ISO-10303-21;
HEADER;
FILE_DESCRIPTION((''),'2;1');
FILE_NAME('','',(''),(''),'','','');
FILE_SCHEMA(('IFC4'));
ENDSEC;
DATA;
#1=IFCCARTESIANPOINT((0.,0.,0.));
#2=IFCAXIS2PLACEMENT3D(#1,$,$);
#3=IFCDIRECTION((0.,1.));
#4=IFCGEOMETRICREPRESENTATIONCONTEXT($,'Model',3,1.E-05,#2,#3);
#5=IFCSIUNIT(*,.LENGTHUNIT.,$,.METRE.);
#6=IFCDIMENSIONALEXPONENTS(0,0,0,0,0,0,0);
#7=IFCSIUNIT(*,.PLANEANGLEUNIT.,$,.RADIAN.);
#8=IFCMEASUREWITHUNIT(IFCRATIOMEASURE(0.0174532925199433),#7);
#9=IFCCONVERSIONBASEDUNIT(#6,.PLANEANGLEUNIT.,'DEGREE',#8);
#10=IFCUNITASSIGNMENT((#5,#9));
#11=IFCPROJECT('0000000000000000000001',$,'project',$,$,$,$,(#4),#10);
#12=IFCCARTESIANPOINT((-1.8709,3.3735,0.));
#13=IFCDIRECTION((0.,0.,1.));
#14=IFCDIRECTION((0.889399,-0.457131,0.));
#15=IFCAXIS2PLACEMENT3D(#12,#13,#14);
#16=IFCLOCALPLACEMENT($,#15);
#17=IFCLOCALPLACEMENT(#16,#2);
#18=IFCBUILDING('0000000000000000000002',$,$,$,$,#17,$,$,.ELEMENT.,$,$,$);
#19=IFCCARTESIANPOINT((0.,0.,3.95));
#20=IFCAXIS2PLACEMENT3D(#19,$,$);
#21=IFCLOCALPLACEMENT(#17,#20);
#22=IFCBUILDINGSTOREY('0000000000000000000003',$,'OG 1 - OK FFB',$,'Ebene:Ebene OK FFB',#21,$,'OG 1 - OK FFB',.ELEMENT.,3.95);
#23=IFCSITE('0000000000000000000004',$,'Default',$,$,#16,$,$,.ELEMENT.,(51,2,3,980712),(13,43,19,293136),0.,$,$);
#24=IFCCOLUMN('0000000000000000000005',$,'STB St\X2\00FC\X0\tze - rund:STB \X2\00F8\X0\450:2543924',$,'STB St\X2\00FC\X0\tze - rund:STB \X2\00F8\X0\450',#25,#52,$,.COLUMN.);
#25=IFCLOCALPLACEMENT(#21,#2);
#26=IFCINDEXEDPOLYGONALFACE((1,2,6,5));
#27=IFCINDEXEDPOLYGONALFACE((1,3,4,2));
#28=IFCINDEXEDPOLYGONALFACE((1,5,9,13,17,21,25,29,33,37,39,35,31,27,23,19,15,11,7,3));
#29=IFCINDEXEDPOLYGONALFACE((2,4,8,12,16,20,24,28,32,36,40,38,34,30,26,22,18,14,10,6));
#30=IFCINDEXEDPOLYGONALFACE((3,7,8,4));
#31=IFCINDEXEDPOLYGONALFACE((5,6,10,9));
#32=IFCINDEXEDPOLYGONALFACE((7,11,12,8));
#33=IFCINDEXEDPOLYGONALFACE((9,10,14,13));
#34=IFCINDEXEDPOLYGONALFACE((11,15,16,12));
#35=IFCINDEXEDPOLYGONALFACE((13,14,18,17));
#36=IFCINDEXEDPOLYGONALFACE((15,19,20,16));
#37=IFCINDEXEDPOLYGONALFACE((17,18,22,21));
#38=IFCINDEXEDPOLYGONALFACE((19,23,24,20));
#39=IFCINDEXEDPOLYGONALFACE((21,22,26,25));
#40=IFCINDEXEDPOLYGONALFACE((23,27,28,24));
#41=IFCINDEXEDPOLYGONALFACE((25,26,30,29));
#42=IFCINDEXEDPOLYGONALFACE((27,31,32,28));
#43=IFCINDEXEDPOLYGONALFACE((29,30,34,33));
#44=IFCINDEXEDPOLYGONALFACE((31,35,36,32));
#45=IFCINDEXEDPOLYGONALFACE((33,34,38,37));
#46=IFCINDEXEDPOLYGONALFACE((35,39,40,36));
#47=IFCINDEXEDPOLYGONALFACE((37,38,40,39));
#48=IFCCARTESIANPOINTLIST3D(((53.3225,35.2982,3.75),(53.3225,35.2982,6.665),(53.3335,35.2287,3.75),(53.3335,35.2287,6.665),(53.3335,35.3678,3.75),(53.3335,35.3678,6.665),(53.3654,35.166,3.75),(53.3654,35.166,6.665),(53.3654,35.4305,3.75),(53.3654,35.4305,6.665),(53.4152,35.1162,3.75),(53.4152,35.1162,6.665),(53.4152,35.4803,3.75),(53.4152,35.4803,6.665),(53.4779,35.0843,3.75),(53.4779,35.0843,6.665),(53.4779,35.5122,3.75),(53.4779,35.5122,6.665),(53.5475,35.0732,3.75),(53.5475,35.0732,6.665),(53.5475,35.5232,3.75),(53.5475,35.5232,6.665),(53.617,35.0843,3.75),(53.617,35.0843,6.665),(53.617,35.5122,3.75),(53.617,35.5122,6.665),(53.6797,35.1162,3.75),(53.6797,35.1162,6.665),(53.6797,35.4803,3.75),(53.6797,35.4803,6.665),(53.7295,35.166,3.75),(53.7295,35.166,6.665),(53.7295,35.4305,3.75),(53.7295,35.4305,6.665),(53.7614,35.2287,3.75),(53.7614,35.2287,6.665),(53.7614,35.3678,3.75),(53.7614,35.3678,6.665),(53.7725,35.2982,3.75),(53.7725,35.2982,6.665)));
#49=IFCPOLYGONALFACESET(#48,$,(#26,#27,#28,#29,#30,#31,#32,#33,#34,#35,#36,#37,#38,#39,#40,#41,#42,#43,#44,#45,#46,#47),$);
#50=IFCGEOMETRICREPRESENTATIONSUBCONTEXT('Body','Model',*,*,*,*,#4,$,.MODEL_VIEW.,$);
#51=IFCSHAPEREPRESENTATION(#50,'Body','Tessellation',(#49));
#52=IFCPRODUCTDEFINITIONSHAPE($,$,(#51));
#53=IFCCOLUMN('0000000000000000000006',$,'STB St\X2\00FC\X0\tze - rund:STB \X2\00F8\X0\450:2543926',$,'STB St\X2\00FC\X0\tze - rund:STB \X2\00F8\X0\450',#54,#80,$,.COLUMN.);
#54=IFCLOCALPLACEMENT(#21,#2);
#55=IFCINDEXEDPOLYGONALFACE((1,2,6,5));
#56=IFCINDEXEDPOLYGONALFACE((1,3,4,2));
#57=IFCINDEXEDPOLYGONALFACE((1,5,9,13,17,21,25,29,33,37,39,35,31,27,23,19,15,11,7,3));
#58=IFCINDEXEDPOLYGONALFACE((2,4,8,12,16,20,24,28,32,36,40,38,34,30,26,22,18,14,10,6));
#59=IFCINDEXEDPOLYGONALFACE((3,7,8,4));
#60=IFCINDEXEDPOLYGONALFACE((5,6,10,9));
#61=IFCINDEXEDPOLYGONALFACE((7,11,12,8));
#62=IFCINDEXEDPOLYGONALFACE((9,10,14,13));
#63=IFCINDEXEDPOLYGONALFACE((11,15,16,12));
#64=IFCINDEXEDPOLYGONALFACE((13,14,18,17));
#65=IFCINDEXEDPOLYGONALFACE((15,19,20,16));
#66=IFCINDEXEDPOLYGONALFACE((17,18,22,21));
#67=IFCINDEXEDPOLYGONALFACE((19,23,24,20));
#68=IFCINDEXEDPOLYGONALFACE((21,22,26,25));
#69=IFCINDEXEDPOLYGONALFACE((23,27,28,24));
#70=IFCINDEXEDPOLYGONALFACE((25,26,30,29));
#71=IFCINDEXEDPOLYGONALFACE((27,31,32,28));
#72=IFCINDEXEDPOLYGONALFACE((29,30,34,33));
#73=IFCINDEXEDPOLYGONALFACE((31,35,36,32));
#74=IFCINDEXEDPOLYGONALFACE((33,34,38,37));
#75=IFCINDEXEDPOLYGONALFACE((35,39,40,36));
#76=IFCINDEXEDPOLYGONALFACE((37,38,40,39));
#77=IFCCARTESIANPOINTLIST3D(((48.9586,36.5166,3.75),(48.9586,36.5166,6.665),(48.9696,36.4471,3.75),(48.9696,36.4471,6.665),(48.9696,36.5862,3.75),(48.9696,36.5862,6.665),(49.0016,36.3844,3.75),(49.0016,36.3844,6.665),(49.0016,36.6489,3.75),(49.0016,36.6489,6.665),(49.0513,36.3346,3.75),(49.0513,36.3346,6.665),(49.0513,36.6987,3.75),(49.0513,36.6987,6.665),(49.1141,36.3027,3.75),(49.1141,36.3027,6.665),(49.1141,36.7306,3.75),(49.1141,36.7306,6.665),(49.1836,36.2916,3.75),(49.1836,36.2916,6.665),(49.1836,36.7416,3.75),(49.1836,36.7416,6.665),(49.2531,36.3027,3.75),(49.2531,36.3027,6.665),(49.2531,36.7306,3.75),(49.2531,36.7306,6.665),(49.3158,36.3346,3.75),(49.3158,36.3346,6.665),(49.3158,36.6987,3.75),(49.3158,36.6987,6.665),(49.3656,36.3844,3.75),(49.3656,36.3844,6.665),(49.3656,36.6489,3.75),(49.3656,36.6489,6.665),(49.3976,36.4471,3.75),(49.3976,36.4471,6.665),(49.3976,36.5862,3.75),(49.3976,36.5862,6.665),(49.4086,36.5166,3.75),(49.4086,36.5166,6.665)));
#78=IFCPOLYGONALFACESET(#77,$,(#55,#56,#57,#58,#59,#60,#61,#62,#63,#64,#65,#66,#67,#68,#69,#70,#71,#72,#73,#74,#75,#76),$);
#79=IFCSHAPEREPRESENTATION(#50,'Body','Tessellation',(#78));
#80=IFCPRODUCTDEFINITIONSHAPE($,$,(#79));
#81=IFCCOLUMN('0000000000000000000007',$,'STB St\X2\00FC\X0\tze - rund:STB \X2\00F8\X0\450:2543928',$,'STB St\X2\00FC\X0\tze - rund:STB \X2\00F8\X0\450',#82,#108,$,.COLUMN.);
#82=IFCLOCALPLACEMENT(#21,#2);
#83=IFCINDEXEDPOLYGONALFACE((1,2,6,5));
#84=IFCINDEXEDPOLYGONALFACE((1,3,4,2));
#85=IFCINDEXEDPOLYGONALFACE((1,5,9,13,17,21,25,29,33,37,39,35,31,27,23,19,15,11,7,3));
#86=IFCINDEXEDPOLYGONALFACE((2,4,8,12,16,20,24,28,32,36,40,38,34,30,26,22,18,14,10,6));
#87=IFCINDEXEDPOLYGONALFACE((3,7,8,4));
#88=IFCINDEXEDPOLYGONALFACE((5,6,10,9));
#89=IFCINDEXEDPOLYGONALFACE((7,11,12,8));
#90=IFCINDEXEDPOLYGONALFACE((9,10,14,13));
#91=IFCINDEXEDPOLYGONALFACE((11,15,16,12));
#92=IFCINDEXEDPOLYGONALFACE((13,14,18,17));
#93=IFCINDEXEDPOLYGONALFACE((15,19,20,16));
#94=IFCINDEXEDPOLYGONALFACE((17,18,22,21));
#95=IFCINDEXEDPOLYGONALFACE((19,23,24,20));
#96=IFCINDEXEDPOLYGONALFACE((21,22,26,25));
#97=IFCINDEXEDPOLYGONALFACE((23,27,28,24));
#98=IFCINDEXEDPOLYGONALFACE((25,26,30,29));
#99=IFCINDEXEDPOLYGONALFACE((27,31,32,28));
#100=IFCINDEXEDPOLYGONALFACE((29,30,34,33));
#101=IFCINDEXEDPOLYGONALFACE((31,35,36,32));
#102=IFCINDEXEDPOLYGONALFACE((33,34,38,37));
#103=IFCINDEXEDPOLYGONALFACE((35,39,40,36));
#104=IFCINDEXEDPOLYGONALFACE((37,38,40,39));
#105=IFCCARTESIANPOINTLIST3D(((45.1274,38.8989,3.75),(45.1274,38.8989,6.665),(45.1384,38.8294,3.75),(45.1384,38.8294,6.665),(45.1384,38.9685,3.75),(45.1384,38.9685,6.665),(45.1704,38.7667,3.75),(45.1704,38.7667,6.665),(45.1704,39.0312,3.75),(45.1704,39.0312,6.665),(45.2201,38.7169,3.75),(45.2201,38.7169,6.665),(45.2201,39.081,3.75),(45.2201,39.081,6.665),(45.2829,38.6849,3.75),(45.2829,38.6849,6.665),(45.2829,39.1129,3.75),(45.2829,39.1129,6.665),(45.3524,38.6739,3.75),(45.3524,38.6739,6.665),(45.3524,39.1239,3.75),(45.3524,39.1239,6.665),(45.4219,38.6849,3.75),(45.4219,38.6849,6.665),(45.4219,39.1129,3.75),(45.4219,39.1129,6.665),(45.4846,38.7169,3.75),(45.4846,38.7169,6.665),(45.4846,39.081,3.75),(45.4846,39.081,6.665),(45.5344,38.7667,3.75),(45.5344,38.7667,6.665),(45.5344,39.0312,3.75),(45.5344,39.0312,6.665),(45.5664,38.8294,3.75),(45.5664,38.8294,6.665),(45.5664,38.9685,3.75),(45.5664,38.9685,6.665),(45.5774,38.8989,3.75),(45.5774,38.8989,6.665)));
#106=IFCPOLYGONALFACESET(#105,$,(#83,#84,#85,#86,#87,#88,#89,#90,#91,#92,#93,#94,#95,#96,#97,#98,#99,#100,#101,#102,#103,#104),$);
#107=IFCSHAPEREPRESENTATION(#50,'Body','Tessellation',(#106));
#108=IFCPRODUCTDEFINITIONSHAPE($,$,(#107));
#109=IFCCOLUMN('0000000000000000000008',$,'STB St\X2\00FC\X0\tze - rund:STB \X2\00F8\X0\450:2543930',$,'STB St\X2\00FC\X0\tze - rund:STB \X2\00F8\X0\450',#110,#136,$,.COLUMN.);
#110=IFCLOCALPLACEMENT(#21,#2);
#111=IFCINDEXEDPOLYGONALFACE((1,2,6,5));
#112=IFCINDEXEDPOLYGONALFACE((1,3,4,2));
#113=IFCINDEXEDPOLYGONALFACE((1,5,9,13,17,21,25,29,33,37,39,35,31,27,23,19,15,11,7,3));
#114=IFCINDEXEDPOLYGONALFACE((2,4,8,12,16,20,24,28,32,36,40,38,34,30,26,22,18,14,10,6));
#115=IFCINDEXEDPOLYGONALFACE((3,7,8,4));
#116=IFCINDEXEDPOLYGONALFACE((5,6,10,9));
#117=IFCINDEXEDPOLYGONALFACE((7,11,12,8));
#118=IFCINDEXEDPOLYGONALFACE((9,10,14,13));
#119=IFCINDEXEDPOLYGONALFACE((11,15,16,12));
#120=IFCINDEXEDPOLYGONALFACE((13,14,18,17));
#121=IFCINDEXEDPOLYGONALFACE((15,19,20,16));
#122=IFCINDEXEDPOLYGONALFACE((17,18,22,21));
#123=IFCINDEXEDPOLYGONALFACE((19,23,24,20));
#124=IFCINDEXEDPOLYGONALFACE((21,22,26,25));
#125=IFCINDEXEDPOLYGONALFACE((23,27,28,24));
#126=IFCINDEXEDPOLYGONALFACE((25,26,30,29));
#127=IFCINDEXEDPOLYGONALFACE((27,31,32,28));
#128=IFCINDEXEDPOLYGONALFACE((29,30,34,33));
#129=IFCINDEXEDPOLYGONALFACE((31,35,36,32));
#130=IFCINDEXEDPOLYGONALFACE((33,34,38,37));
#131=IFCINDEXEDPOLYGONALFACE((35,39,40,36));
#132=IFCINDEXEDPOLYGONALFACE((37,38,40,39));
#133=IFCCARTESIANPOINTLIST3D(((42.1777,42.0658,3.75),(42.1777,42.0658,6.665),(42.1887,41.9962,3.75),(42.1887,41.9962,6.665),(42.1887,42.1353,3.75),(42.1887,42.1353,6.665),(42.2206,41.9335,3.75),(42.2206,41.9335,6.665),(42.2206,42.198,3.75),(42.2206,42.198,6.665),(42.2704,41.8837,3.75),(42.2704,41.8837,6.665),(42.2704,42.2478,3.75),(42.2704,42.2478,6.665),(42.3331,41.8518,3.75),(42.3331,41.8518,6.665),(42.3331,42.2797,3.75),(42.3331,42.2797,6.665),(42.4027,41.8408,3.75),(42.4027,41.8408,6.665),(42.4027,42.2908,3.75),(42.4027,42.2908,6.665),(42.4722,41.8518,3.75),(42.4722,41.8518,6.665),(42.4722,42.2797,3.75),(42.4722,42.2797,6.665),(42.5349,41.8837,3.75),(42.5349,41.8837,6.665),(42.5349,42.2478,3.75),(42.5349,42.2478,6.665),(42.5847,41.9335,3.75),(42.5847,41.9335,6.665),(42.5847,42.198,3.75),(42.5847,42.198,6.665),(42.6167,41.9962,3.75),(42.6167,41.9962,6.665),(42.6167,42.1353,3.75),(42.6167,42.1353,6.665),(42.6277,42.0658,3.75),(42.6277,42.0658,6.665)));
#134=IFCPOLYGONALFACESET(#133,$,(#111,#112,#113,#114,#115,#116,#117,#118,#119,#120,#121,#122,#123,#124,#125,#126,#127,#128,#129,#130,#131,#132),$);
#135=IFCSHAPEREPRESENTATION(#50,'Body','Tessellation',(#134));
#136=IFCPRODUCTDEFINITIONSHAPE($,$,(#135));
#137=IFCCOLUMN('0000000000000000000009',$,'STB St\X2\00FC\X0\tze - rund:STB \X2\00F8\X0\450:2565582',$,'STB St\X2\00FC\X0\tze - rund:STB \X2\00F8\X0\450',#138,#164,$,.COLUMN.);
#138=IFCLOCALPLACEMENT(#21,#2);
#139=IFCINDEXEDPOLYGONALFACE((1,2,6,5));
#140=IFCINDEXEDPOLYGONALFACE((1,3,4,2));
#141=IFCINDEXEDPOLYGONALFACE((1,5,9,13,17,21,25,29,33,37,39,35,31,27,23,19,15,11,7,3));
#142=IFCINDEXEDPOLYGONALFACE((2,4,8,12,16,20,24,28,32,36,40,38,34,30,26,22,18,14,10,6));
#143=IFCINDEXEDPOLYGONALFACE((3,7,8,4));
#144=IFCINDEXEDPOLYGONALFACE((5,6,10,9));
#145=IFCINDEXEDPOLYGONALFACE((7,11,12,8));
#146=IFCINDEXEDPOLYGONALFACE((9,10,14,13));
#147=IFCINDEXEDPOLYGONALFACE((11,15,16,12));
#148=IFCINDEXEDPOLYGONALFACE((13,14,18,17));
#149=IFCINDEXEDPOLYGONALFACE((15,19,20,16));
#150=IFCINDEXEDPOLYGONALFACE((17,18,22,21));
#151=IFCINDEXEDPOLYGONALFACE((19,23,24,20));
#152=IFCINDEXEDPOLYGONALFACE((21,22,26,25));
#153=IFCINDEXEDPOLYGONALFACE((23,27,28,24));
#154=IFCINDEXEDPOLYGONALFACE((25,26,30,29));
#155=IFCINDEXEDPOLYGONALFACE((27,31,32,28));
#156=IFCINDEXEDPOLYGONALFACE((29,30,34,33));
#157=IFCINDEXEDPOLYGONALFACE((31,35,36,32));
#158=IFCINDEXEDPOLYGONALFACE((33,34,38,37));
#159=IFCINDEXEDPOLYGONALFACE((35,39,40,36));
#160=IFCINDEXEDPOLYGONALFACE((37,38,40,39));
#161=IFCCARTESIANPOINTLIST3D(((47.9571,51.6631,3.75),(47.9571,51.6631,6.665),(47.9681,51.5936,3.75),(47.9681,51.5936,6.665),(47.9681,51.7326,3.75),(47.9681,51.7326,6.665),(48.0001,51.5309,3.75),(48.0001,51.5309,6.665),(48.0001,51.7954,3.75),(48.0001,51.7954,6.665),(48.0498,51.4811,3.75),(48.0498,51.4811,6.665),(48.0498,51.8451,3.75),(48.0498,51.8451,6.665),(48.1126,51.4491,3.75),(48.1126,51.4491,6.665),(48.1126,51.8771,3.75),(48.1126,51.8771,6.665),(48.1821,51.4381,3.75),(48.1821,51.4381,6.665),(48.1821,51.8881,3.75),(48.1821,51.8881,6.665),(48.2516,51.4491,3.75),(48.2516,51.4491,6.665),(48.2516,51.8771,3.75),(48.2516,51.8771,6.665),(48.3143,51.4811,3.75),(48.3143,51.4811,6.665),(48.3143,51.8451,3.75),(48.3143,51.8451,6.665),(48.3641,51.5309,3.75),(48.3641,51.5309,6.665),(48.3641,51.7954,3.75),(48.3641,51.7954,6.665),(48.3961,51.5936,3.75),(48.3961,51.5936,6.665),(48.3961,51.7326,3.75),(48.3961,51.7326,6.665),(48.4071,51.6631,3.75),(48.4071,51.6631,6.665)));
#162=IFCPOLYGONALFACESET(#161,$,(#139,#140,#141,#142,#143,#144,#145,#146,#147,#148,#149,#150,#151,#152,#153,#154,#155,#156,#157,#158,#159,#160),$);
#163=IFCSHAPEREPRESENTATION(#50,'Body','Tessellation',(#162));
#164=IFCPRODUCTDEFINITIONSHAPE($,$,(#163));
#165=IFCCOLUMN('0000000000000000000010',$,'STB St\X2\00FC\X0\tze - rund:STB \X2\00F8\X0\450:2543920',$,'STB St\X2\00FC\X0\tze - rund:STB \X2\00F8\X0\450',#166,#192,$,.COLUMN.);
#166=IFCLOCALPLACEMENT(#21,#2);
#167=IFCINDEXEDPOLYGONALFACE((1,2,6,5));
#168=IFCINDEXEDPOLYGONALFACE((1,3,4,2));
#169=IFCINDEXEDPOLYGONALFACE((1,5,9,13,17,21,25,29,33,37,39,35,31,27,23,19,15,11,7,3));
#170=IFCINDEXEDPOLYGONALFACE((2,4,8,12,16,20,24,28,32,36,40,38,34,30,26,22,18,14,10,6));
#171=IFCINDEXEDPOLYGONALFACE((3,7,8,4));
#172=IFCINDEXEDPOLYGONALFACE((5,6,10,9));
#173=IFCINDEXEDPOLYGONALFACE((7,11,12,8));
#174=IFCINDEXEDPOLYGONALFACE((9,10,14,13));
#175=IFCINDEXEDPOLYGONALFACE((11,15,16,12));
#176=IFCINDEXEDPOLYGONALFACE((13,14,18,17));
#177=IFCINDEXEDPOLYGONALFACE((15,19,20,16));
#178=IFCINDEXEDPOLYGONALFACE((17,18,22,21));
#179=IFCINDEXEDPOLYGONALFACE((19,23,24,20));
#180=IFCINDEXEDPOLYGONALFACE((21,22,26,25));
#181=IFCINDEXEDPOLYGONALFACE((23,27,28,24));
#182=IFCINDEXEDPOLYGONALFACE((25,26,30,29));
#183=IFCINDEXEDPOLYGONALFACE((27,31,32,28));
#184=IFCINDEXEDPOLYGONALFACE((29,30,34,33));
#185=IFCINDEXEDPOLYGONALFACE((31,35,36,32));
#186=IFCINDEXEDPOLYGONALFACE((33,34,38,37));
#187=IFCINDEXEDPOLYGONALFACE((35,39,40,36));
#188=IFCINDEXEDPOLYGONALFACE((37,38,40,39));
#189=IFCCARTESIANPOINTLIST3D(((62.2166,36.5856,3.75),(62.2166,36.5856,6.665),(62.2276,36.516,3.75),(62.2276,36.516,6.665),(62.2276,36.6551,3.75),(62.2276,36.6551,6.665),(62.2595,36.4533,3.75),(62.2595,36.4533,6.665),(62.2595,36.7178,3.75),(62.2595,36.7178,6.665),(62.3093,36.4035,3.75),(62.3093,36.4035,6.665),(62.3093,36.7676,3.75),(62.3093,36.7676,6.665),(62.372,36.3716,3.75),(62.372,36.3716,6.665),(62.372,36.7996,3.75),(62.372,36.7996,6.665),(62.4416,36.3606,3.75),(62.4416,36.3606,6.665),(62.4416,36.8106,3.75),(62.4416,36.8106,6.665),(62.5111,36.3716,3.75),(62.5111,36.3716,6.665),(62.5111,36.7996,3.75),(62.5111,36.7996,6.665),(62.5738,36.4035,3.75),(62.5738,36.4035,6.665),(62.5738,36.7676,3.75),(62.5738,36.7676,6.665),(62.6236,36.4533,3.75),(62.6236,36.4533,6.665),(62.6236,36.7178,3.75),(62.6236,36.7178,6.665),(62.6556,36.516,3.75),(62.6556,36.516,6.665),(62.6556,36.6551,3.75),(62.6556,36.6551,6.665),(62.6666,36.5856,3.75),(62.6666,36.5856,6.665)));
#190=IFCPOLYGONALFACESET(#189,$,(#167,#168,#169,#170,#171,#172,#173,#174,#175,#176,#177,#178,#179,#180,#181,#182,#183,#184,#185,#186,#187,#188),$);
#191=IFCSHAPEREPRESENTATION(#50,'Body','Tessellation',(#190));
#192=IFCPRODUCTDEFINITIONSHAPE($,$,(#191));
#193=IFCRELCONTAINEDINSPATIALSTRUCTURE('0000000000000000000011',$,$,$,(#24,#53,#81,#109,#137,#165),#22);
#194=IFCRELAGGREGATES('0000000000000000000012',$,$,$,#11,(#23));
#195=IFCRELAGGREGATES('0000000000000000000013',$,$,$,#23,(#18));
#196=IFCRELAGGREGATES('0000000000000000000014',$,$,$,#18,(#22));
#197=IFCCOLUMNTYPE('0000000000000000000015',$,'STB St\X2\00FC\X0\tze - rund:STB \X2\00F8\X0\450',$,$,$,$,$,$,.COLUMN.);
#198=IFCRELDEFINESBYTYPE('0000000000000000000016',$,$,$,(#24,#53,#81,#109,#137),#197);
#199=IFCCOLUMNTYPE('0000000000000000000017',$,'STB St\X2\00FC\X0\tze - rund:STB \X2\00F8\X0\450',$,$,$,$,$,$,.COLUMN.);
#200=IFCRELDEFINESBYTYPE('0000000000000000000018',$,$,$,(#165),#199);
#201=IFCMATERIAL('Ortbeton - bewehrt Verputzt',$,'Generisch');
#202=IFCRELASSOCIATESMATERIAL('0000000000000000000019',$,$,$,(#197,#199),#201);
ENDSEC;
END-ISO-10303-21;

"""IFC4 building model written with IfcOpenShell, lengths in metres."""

from ifc_helpers import new_model, entity, si_unit, converted_unit, direction, frame, origin, place, context, subcontext, project, spatial, indexed_curve, outline, extrude, source, transform, mapped, material, type_object, type_shapes, element, save


model = new_model("IFC4")

# Units and contexts
model_context = context("Model", 3, precision=1e-05, world=origin(), true_north=direction((0.0, 1.0)))
body_context = subcontext(model_context, "Body", "Model", "MODEL_VIEW")
ifc_project = project(units=[si_unit("LENGTHUNIT", "METRE"), converted_unit("PLANEANGLEUNIT", "DEGREE", entity("IfcRatioMeasure", 0.0174532925199433), si_unit("PLANEANGLEUNIT", "RADIAN"), dimensions=[0, 0, 0, 0, 0, 0, 0])], contexts=[model_context])

# Site, building, storey
site_placement = place(None, frame((-1.8709, 3.3735, 0.0), z_axis=(0.0, 0.0, 1.0), x_axis=(0.889399, -0.457131, 0.0)))
site = spatial("IfcSite", under=ifc_project, at=site_placement, Name="Default", CompositionType="ELEMENT", RefLatitude=(51, 2, 3, 980712), RefLongitude=(13, 43, 19, 293136), RefElevation=0.0)
building_placement = place(site_placement, origin())
building = spatial("IfcBuilding", under=site, at=building_placement, CompositionType="ELEMENT")
storey_placement = place(building_placement, frame((0.0, 0.0, 3.95)))
storey = spatial("IfcBuildingStorey", under=building, at=storey_placement, Name="OG 1 - OK FFB", ObjectType="Ebene:Ebene OK FFB", LongName="OG 1 - OK FFB", CompositionType="ELEMENT", Elevation=3.95)

# Columns
ifc_material_1 = material(Name="Ortbeton - bewehrt Verputzt", Category="Generisch")
column_type_1 = type_object("IfcColumnType", Name="STB Stütze - rund:STB ø450", PredefinedType="COLUMN", material=ifc_material_1)
shared_shape_1 = source(origin(), body_context, "Body", "SweptSolid", [
    extrude(outline(indexed_curve([(0.225, 0.0), (0.214, 0.0695), (0.182, 0.1323), (0.1323, 0.182), (0.0695, 0.214), (0.0, 0.225), (-0.0695, 0.214), (-0.1323, 0.182), (-0.182, 0.1323), (-0.214, 0.0695), (-0.225, 0.0), (-0.214, -0.0695), (-0.182, -0.1323), (-0.1323, -0.182), (-0.0695, -0.214), (0.0, -0.225), (0.0695, -0.214), (0.1323, -0.182), (0.182, -0.1323), (0.214, -0.0695), (0.225, 0.0)], self_intersect=False)), frame((0.0, 0.0, 7.7), z_axis=(0.0, 0.0, 1.0), x_axis=(-1.0, 0.0, 0.0)), (0.0, 0.0, 1.0), 2.915),
])
type_shapes(column_type_1, [shared_shape_1])
for number, where, name in (
    (1, (53.5475, 35.2982, -3.95), "STB Stütze - rund:STB ø450:2543924"),
    (2, (49.1836, 36.5166, -3.95), "STB Stütze - rund:STB ø450:2543926"),
    (3, (45.3524, 38.8989, -3.95), "STB Stütze - rund:STB ø450:2543928"),
    (4, (42.4027, 42.0658, -3.95), "STB Stütze - rund:STB ø450:2543930"),
    (5, (48.1821, 51.6631, -3.95), "STB Stütze - rund:STB ø450:2565582"),
):
    element("IfcColumn", number, at=place(storey_placement, frame(where)), inside=storey, type_object=column_type_1, Name=name, ObjectType="STB Stütze - rund:STB ø450", PredefinedType="COLUMN", context=body_context, shape_type="MappedRepresentation", body=[
        mapped(shared_shape_1, transform((0.0, 0.0, 0.0), scale=1.0)),
    ])
column_type_2 = type_object("IfcColumnType", Name="STB Stütze - rund:STB ø450", PredefinedType="COLUMN", material=ifc_material_1)
shared_shape_2 = source(origin(), body_context, "Body", "SweptSolid", [
    extrude(outline(indexed_curve([(0.225, 0.0), (0.214, 0.0695), (0.182, 0.1323), (0.1323, 0.182), (0.0695, 0.214), (0.0, 0.225), (-0.0695, 0.214), (-0.1323, 0.182), (-0.182, 0.1323), (-0.214, 0.0695), (-0.225, 0.0), (-0.214, -0.0695), (-0.182, -0.1323), (-0.1323, -0.182), (-0.0695, -0.214), (0.0, -0.225), (0.0695, -0.214), (0.1323, -0.182), (0.182, -0.1323), (0.214, -0.0695), (0.225, 0.0)], self_intersect=False)), frame((62.4416, 36.5856, 7.7), z_axis=(0.0, 0.0, 1.0), x_axis=(-1.0, 0.0, 0.0)), (0.0, 0.0, 1.0), 2.915),
])
type_shapes(column_type_2, [shared_shape_2])
column_placement = place(storey_placement, frame((0.0, 0.0, -3.95)))
element("IfcColumn", 6, at=column_placement, inside=storey, type_object=column_type_2, Name="STB Stütze - rund:STB ø450:2543920", ObjectType="STB Stütze - rund:STB ø450", PredefinedType="COLUMN", context=body_context, shape_type="MappedRepresentation", body=[
    mapped(shared_shape_2, transform((0.0, 0.0, 0.0), scale=1.0)),
])

save(model, "model.ifc")
